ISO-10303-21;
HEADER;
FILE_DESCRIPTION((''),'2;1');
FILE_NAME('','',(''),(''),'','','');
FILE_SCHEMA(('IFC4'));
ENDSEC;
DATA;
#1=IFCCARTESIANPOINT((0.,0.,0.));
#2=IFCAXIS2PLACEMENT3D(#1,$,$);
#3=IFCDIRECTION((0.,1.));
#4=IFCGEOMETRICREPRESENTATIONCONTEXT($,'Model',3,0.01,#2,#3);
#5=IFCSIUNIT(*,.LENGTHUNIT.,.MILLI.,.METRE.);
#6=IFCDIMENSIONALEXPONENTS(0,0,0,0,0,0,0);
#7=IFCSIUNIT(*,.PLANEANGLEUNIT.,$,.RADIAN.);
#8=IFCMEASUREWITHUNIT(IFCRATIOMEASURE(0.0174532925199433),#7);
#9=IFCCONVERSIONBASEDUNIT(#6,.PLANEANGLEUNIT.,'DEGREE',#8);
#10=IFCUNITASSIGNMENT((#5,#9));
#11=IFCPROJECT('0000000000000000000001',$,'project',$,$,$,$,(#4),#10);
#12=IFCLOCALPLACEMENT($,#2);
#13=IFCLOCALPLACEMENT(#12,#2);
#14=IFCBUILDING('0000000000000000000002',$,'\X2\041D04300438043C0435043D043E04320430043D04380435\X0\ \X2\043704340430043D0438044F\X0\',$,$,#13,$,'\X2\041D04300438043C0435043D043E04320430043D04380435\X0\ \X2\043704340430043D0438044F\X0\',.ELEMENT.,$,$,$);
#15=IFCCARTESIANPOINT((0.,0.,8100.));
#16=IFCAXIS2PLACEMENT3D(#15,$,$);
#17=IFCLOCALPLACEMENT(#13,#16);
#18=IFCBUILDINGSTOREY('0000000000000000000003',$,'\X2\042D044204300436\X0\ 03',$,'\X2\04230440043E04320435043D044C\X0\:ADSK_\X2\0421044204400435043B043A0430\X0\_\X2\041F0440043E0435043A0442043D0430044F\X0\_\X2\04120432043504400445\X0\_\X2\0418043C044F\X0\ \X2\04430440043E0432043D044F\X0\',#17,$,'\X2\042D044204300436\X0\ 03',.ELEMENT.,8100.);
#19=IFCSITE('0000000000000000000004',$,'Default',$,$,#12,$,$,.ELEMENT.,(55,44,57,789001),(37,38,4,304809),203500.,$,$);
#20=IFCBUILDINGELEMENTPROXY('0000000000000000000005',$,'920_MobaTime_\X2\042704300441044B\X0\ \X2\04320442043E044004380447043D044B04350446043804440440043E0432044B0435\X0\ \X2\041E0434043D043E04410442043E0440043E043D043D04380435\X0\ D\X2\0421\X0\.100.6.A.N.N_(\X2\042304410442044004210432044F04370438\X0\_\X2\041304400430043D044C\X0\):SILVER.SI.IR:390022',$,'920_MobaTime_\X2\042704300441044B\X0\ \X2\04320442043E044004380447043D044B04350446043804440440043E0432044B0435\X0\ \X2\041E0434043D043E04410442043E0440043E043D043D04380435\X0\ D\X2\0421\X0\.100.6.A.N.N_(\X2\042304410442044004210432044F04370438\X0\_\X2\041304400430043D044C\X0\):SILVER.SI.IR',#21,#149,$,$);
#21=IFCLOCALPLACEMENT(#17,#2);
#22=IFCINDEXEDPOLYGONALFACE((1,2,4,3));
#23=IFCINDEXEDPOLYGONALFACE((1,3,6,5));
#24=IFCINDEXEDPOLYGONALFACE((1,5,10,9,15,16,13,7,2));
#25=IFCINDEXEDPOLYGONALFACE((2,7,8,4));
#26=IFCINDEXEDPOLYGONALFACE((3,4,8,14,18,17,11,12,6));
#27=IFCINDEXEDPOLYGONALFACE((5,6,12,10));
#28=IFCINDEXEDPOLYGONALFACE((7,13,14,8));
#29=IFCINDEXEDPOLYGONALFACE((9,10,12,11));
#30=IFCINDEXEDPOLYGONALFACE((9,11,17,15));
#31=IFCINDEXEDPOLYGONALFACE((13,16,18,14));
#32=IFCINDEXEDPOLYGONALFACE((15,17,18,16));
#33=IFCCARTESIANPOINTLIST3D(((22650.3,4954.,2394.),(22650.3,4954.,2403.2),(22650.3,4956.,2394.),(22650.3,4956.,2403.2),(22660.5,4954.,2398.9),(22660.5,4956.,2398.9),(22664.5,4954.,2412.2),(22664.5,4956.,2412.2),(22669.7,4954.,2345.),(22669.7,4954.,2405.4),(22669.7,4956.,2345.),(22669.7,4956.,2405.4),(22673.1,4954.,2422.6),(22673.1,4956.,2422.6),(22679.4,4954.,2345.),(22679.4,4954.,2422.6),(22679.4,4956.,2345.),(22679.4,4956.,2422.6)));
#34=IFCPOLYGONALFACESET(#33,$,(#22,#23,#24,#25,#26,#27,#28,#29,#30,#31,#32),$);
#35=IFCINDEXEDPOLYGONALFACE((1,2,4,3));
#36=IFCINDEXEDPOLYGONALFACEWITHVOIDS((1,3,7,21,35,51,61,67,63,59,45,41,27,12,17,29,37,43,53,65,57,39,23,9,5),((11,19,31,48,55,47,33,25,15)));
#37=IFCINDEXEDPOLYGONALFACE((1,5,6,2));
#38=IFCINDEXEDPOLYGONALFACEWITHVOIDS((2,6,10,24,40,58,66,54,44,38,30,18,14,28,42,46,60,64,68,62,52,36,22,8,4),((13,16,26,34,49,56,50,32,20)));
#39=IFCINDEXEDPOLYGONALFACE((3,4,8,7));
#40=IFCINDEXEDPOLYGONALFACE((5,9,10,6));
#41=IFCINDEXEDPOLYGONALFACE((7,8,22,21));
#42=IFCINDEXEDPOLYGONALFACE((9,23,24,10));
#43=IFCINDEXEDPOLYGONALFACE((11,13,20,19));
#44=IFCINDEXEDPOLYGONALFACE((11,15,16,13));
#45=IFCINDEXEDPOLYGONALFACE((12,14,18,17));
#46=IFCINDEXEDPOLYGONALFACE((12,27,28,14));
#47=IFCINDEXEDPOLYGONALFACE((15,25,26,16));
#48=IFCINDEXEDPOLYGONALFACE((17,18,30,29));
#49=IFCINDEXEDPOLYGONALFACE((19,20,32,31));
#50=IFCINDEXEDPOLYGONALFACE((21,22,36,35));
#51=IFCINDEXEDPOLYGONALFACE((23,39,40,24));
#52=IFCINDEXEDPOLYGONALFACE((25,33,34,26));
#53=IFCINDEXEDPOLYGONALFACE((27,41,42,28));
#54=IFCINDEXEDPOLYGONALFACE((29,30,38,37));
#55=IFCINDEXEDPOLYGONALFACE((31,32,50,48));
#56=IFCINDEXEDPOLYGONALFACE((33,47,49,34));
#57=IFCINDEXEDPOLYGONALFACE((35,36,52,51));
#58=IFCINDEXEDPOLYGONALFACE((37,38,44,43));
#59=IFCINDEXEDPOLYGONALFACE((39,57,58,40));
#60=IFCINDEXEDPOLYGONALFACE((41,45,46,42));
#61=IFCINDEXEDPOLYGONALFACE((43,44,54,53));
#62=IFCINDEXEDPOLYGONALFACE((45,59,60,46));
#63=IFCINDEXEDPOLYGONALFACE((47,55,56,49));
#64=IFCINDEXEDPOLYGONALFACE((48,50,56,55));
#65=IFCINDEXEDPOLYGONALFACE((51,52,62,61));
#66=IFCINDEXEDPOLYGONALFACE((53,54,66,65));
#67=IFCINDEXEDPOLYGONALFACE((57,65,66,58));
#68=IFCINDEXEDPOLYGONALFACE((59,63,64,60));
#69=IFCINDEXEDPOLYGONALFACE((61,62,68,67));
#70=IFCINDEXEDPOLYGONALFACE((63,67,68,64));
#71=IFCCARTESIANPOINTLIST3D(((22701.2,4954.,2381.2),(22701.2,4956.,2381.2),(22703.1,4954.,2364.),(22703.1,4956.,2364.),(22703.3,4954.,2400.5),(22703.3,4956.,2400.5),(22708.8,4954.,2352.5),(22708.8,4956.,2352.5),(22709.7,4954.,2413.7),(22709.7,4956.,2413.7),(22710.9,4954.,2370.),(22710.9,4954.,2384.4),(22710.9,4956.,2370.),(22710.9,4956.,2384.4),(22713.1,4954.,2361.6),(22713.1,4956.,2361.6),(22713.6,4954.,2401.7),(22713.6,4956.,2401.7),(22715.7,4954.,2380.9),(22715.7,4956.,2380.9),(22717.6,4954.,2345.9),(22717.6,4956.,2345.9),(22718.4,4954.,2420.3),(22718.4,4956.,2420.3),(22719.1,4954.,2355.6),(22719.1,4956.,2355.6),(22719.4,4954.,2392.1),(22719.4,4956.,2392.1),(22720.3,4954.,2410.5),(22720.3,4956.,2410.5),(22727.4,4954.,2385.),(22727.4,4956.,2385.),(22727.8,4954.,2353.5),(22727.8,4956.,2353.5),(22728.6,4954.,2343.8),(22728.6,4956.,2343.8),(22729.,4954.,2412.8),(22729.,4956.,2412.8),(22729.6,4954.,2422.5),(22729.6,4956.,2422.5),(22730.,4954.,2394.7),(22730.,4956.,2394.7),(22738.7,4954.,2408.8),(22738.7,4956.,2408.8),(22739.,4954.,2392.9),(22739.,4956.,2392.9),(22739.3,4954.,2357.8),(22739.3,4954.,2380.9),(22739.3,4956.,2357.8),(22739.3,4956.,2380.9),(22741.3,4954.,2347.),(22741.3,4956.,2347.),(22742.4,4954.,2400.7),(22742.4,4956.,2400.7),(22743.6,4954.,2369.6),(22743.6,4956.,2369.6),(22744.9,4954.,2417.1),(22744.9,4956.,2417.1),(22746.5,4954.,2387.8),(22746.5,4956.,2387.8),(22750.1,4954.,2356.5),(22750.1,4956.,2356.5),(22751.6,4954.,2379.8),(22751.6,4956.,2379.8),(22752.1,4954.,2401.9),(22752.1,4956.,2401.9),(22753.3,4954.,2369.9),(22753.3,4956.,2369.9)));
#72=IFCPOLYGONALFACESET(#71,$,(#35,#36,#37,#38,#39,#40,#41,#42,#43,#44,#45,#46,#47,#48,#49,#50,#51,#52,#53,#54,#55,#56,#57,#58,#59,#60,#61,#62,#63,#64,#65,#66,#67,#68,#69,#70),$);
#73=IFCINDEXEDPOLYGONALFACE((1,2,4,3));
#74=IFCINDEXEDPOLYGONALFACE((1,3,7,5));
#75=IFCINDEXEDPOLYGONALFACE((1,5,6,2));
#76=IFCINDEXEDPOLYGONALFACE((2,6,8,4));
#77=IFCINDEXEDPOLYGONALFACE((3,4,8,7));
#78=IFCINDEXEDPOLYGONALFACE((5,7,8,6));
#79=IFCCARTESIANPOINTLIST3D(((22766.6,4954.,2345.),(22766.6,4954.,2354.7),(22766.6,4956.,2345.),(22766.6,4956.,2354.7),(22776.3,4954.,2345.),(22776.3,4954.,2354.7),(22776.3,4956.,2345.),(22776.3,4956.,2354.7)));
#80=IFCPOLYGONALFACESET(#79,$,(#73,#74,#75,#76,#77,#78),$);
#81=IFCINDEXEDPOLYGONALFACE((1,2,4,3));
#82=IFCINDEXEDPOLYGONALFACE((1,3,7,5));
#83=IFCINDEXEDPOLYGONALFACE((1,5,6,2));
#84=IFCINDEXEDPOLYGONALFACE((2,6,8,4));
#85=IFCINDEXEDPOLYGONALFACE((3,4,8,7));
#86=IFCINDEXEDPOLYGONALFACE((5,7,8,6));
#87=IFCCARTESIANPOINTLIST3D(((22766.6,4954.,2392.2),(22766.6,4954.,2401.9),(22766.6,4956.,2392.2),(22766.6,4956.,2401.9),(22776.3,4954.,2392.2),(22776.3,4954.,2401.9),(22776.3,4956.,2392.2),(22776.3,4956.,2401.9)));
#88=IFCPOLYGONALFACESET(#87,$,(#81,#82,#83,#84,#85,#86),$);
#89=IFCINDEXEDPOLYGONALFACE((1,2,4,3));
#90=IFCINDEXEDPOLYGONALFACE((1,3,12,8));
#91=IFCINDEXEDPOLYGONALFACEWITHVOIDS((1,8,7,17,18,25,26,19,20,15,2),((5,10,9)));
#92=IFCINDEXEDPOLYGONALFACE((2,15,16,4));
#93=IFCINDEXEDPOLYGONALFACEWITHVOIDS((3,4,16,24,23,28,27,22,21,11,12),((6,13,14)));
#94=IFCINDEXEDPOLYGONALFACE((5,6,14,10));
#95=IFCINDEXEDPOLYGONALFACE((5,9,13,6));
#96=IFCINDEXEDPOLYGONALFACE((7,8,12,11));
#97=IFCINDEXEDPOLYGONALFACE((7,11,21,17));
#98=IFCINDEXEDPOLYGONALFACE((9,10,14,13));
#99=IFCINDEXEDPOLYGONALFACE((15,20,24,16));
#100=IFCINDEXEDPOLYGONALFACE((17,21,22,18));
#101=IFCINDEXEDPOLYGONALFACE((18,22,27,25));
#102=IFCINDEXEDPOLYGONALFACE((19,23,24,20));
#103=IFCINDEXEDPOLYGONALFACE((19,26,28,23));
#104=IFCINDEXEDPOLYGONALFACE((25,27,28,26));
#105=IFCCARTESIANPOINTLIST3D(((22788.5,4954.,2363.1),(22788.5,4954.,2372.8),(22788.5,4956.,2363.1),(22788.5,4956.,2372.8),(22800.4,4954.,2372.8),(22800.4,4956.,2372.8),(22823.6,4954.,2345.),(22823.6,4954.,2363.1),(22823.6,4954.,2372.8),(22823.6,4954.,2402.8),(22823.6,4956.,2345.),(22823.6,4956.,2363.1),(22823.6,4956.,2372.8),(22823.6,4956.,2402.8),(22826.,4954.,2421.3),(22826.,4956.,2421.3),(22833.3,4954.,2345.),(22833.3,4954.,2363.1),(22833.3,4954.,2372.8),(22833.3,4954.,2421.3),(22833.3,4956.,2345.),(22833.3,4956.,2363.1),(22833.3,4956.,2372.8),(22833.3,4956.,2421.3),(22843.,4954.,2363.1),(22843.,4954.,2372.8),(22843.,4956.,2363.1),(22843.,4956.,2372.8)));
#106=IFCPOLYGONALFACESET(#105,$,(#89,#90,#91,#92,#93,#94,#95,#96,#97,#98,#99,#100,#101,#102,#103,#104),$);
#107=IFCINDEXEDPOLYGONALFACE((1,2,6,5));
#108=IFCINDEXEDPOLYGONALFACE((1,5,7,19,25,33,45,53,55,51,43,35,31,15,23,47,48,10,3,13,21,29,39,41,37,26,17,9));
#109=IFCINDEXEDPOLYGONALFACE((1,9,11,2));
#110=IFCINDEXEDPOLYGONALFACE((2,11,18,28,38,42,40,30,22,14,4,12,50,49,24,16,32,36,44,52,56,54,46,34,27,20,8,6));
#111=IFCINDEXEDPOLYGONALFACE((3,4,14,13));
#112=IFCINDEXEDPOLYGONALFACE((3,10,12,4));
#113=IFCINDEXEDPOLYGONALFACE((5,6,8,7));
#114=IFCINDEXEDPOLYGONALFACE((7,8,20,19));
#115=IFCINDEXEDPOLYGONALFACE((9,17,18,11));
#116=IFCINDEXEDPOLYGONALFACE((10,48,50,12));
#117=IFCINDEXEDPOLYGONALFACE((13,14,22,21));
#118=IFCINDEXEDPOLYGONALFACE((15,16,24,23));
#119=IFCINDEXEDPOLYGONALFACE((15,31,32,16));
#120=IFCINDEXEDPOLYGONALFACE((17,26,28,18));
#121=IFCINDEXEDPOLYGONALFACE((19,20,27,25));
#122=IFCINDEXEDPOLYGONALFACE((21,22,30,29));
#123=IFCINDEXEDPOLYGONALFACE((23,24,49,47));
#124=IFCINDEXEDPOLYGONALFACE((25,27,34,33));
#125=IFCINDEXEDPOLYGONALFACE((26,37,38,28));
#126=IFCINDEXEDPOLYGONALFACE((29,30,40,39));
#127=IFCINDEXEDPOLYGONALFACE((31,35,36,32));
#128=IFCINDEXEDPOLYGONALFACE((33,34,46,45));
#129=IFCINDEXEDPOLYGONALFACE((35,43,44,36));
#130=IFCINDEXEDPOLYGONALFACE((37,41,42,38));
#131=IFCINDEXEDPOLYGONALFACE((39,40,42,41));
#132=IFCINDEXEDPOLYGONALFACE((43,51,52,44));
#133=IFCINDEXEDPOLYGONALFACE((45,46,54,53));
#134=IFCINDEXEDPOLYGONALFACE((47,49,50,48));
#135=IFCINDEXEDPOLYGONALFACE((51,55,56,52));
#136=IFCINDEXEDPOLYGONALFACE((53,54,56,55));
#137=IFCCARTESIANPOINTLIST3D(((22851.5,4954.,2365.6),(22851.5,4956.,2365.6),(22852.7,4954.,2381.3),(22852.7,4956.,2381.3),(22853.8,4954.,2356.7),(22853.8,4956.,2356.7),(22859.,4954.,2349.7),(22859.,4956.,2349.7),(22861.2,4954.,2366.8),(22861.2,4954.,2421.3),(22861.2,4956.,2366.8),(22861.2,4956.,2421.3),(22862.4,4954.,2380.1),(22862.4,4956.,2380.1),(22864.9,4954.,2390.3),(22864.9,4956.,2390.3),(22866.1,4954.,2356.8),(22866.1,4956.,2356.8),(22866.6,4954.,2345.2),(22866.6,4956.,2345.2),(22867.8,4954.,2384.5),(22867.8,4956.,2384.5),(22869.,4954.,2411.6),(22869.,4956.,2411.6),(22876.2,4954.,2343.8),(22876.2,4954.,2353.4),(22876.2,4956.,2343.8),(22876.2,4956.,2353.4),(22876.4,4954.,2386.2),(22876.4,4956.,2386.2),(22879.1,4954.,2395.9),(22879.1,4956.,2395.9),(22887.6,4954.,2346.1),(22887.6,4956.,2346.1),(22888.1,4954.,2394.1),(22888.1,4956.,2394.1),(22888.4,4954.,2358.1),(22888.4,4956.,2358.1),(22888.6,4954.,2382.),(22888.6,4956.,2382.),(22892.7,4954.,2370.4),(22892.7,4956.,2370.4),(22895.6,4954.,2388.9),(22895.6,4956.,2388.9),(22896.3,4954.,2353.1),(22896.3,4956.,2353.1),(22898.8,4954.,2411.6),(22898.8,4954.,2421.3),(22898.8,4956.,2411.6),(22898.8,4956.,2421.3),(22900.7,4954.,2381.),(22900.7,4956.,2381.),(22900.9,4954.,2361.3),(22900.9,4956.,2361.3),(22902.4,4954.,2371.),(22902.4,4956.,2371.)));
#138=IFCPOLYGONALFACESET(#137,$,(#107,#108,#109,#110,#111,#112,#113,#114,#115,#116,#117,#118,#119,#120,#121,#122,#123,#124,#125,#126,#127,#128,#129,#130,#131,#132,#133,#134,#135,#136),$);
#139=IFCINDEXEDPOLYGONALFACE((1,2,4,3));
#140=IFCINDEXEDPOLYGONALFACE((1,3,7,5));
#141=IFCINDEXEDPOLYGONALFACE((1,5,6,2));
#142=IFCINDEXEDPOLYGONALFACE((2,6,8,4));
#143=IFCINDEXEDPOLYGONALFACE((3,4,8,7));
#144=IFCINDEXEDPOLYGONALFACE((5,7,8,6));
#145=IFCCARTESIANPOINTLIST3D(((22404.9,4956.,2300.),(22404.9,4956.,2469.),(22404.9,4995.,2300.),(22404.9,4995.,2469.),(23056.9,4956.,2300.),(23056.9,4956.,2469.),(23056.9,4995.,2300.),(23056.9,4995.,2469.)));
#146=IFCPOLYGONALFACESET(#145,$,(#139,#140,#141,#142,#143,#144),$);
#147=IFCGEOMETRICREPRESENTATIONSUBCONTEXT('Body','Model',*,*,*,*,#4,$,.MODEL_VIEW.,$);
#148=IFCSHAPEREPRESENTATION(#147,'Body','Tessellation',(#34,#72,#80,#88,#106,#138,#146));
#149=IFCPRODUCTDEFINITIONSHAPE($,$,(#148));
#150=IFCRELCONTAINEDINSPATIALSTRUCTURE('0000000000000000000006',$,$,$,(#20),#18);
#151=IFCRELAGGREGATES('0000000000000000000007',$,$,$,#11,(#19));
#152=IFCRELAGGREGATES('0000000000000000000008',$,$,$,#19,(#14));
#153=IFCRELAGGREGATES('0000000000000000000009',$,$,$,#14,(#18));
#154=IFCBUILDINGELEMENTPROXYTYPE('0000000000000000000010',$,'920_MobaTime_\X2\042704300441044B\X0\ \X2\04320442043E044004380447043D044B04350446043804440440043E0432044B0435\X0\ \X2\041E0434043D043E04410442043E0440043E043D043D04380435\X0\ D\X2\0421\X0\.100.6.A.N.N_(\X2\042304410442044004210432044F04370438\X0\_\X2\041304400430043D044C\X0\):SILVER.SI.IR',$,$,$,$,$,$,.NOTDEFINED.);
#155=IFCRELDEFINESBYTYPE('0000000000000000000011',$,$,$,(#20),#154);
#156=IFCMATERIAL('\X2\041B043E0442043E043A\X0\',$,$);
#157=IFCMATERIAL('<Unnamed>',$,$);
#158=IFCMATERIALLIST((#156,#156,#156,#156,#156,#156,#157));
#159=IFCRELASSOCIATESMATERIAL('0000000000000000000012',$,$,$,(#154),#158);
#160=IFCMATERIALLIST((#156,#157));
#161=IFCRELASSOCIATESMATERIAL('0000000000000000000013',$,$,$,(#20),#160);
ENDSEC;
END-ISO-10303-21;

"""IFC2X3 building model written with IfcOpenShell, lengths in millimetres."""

from ifc_helpers import new_model, entity, si_unit, converted_unit, direction, frame, origin, origin_2d_with_axis, place, context, subcontext, project, spatial, polyline, rectangle, outline, extrude, source, transform, mapped, material, material_list, type_object, type_shapes, element, save


model = new_model("IFC2X3")

# Units and contexts
model_context = context("Model", 3, precision=0.01, world=origin(), true_north=direction((0.0, 1.0)))
body_context = subcontext(model_context, "Body", "Model", "MODEL_VIEW")
ifc_project = project(units=[si_unit("LENGTHUNIT", "METRE", prefix="MILLI"), converted_unit("PLANEANGLEUNIT", "DEGREE", entity("IfcRatioMeasure", 0.0174532925199433), si_unit("PLANEANGLEUNIT", "RADIAN"), dimensions=[0, 0, 0, 0, 0, 0, 0])], contexts=[model_context])

# Site, building, storey
site_placement = place(None, origin())
site = spatial("IfcSite", under=ifc_project, at=site_placement, Name="Default", CompositionType="ELEMENT", RefLatitude=(55, 44, 57, 789001), RefLongitude=(37, 38, 4, 304809), RefElevation=203500.0)
building_placement = place(site_placement, origin())
building = spatial("IfcBuilding", under=site, at=building_placement, Name="Наименование здания", LongName="Наименование здания", CompositionType="ELEMENT")
storey_placement = place(building_placement, frame((0.0, 0.0, 8100.0)))
storey = spatial("IfcBuildingStorey", under=building, at=storey_placement, Name="Этаж 03", ObjectType="Уровень:ADSK_Стрелка_Проектная_Вверх_Имя уровня", LongName="Этаж 03", CompositionType="ELEMENT", Elevation=8100.0)

# Building element proxy
ifc_material_1 = material(Name="Лоток")
ifc_material_2 = material(Name="<Unnamed>")
ifc_material_list_1 = material_list([ifc_material_1, ifc_material_1, ifc_material_1, ifc_material_1, ifc_material_1, ifc_material_1, ifc_material_2])
building_element_proxy_type = type_object("IfcBuildingElementProxyType", Name="920_MobaTime_Часы вторичныецифровые Односторонние DС.100.6.A.N.N_(УстрСвязи_Грань):SILVER.SI.IR", PredefinedType="NOTDEFINED", material=ifc_material_list_1)
shared_shape = source(origin(), body_context, "Body", "SweptSolid", [
    extrude(outline(polyline([(-49.3, -13.1), (28.2, -13.1), (28.2, -6.8), (17.9, 1.8), (8.8, 16.0), (-0.3, 16.0), (4.6, 5.8), (11.1, -3.4), (-49.3, -3.4), (-49.3, -13.1)])), frame((-64.6, 9.8, 39.0), z_axis=(0.0, 0.0, 1.0), x_axis=(0.0, 1.0, 0.0)), (0.0, 0.0, 1.0), 2.0),
    extrude(outline(polyline([(2.2, -27.6), (19.0, -27.6), (30.5, -16.1), (33.3, -4.9), (31.0, 5.8), (21.8, 17.2), (5.2, 27.3), (-11.1, 33.0), (-24.0, 32.7), (-33.6, 27.6), (-40.3, 18.6), (-42.8, 5.7), (-38.0, -6.3), (-27.2, -14.9), (-17.5, -17.7), (-8.2, -16.4), (-0.3, -11.9), (5.1, -4.5), (7.3, 6.2), (4.0, 17.2), (18.4, 7.3), (23.6, -2.4), (22.0, -11.4), (14.2, -18.4), (5.3, -18.3), (2.2, -27.6)]), holes=[polyline([(-9.0, 23.3), (-1.3, 14.3), (-2.5, 2.0), (-11.4, -7.0), (-23.4, -6.0), (-32.2, 2.9), (-31.2, 15.1), (-25.6, 22.1), (-17.5, 24.9), (-9.0, 23.3)])]), frame((-2.7, 3.6, 39.0), z_axis=(0.0, 0.0, 1.0), x_axis=(-0.427649, 0.903945, 0.0)), (0.0, 0.0, 1.0), 2.0),
    extrude(rectangle(XDim=9.7, YDim=9.7, at=origin_2d_with_axis()), frame((40.6, -34.7, 39.0)), (0.0, 0.0, 1.0), 2.0),
    extrude(rectangle(XDim=9.7, YDim=9.7, at=origin_2d_with_axis()), frame((40.6, 12.6, 39.0)), (0.0, 0.0, 1.0), 2.0),
    extrude(outline(polyline([(-0.9, -28.1), (8.8, -28.1), (8.8, -9.9), (18.5, -9.9), (18.5, -0.2), (8.8, -0.2), (8.8, 48.3), (1.5, 48.3), (-36.0, -0.2), (-36.0, -9.9), (-0.9, -9.9), (-0.9, -28.1)]), holes=[polyline([(-0.9, -0.2), (-24.1, -0.2), (-0.9, 29.7), (-0.9, -0.2)])]), frame((93.6, -11.4, 39.0)), (0.0, 0.0, 1.0), 2.0),
    extrude(outline(polyline([(3.3, -28.3), (12.5, -28.3), (20.5, -25.0), (26.8, -18.9), (30.7, -10.0), (31.4, 1.6), (26.9, 11.8), (20.1, 18.4), (11.1, 22.3), (1.0, 23.3), (-7.9, 20.4), (-14.9, 14.5), (-18.9, 6.2), (-17.1, -9.0), (-36.7, 0.5), (-29.1, 29.2), (-38.5, 31.7), (-48.1, -4.6), (-11.6, -23.1), (-8.0, -14.0), (-10.8, -7.6), (-10.2, 1.1), (-3.0, 11.8), (9.2, 12.8), (20.0, 5.5), (21.4, -7.5), (15.5, -16.4), (4.6, -18.6), (3.3, -28.3)])), frame((147.1, -8.5, 39.0), z_axis=(0.0, 0.0, 1.0), x_axis=(0.256974, -0.966418, 0.0)), (0.0, 0.0, 1.0), 2.0),
    extrude(rectangle(XDim=652.0, YDim=169.0, at=origin_2d_with_axis()), frame((0.0, 0.0, 0.0), z_axis=(0.0, 0.0, 1.0), x_axis=(-1.0, 0.0, 0.0)), (0.0, 0.0, 1.0), 39.0),
])
type_shapes(building_element_proxy_type, [shared_shape])
ifc_material_list_2 = material_list([ifc_material_1, ifc_material_2])
for number, where, z_axis, x_axis, name in (
    (1, (22730.9, 4995.0, 2384.5), (0.0, -1.0, 0.0), (1.0, 0.0, 0.0), "920_MobaTime_Часы вторичныецифровые Односторонние DС.100.6.A.N.N_(УстрСвязи_Грань):SILVER.SI.IR:390022"),
):
    element("IfcBuildingElementProxy", number, at=place(storey_placement, frame(where, z_axis=z_axis, x_axis=x_axis)), inside=storey, type_object=building_element_proxy_type, material=ifc_material_list_2, Name=name, ObjectType="920_MobaTime_Часы вторичныецифровые Односторонние DС.100.6.A.N.N_(УстрСвязи_Грань):SILVER.SI.IR", context=body_context, shape_type="MappedRepresentation", body=[
        mapped(shared_shape, transform((0.0, 0.0, 0.0), scale=1.0)),
    ])

save(model, "model.ifc")
